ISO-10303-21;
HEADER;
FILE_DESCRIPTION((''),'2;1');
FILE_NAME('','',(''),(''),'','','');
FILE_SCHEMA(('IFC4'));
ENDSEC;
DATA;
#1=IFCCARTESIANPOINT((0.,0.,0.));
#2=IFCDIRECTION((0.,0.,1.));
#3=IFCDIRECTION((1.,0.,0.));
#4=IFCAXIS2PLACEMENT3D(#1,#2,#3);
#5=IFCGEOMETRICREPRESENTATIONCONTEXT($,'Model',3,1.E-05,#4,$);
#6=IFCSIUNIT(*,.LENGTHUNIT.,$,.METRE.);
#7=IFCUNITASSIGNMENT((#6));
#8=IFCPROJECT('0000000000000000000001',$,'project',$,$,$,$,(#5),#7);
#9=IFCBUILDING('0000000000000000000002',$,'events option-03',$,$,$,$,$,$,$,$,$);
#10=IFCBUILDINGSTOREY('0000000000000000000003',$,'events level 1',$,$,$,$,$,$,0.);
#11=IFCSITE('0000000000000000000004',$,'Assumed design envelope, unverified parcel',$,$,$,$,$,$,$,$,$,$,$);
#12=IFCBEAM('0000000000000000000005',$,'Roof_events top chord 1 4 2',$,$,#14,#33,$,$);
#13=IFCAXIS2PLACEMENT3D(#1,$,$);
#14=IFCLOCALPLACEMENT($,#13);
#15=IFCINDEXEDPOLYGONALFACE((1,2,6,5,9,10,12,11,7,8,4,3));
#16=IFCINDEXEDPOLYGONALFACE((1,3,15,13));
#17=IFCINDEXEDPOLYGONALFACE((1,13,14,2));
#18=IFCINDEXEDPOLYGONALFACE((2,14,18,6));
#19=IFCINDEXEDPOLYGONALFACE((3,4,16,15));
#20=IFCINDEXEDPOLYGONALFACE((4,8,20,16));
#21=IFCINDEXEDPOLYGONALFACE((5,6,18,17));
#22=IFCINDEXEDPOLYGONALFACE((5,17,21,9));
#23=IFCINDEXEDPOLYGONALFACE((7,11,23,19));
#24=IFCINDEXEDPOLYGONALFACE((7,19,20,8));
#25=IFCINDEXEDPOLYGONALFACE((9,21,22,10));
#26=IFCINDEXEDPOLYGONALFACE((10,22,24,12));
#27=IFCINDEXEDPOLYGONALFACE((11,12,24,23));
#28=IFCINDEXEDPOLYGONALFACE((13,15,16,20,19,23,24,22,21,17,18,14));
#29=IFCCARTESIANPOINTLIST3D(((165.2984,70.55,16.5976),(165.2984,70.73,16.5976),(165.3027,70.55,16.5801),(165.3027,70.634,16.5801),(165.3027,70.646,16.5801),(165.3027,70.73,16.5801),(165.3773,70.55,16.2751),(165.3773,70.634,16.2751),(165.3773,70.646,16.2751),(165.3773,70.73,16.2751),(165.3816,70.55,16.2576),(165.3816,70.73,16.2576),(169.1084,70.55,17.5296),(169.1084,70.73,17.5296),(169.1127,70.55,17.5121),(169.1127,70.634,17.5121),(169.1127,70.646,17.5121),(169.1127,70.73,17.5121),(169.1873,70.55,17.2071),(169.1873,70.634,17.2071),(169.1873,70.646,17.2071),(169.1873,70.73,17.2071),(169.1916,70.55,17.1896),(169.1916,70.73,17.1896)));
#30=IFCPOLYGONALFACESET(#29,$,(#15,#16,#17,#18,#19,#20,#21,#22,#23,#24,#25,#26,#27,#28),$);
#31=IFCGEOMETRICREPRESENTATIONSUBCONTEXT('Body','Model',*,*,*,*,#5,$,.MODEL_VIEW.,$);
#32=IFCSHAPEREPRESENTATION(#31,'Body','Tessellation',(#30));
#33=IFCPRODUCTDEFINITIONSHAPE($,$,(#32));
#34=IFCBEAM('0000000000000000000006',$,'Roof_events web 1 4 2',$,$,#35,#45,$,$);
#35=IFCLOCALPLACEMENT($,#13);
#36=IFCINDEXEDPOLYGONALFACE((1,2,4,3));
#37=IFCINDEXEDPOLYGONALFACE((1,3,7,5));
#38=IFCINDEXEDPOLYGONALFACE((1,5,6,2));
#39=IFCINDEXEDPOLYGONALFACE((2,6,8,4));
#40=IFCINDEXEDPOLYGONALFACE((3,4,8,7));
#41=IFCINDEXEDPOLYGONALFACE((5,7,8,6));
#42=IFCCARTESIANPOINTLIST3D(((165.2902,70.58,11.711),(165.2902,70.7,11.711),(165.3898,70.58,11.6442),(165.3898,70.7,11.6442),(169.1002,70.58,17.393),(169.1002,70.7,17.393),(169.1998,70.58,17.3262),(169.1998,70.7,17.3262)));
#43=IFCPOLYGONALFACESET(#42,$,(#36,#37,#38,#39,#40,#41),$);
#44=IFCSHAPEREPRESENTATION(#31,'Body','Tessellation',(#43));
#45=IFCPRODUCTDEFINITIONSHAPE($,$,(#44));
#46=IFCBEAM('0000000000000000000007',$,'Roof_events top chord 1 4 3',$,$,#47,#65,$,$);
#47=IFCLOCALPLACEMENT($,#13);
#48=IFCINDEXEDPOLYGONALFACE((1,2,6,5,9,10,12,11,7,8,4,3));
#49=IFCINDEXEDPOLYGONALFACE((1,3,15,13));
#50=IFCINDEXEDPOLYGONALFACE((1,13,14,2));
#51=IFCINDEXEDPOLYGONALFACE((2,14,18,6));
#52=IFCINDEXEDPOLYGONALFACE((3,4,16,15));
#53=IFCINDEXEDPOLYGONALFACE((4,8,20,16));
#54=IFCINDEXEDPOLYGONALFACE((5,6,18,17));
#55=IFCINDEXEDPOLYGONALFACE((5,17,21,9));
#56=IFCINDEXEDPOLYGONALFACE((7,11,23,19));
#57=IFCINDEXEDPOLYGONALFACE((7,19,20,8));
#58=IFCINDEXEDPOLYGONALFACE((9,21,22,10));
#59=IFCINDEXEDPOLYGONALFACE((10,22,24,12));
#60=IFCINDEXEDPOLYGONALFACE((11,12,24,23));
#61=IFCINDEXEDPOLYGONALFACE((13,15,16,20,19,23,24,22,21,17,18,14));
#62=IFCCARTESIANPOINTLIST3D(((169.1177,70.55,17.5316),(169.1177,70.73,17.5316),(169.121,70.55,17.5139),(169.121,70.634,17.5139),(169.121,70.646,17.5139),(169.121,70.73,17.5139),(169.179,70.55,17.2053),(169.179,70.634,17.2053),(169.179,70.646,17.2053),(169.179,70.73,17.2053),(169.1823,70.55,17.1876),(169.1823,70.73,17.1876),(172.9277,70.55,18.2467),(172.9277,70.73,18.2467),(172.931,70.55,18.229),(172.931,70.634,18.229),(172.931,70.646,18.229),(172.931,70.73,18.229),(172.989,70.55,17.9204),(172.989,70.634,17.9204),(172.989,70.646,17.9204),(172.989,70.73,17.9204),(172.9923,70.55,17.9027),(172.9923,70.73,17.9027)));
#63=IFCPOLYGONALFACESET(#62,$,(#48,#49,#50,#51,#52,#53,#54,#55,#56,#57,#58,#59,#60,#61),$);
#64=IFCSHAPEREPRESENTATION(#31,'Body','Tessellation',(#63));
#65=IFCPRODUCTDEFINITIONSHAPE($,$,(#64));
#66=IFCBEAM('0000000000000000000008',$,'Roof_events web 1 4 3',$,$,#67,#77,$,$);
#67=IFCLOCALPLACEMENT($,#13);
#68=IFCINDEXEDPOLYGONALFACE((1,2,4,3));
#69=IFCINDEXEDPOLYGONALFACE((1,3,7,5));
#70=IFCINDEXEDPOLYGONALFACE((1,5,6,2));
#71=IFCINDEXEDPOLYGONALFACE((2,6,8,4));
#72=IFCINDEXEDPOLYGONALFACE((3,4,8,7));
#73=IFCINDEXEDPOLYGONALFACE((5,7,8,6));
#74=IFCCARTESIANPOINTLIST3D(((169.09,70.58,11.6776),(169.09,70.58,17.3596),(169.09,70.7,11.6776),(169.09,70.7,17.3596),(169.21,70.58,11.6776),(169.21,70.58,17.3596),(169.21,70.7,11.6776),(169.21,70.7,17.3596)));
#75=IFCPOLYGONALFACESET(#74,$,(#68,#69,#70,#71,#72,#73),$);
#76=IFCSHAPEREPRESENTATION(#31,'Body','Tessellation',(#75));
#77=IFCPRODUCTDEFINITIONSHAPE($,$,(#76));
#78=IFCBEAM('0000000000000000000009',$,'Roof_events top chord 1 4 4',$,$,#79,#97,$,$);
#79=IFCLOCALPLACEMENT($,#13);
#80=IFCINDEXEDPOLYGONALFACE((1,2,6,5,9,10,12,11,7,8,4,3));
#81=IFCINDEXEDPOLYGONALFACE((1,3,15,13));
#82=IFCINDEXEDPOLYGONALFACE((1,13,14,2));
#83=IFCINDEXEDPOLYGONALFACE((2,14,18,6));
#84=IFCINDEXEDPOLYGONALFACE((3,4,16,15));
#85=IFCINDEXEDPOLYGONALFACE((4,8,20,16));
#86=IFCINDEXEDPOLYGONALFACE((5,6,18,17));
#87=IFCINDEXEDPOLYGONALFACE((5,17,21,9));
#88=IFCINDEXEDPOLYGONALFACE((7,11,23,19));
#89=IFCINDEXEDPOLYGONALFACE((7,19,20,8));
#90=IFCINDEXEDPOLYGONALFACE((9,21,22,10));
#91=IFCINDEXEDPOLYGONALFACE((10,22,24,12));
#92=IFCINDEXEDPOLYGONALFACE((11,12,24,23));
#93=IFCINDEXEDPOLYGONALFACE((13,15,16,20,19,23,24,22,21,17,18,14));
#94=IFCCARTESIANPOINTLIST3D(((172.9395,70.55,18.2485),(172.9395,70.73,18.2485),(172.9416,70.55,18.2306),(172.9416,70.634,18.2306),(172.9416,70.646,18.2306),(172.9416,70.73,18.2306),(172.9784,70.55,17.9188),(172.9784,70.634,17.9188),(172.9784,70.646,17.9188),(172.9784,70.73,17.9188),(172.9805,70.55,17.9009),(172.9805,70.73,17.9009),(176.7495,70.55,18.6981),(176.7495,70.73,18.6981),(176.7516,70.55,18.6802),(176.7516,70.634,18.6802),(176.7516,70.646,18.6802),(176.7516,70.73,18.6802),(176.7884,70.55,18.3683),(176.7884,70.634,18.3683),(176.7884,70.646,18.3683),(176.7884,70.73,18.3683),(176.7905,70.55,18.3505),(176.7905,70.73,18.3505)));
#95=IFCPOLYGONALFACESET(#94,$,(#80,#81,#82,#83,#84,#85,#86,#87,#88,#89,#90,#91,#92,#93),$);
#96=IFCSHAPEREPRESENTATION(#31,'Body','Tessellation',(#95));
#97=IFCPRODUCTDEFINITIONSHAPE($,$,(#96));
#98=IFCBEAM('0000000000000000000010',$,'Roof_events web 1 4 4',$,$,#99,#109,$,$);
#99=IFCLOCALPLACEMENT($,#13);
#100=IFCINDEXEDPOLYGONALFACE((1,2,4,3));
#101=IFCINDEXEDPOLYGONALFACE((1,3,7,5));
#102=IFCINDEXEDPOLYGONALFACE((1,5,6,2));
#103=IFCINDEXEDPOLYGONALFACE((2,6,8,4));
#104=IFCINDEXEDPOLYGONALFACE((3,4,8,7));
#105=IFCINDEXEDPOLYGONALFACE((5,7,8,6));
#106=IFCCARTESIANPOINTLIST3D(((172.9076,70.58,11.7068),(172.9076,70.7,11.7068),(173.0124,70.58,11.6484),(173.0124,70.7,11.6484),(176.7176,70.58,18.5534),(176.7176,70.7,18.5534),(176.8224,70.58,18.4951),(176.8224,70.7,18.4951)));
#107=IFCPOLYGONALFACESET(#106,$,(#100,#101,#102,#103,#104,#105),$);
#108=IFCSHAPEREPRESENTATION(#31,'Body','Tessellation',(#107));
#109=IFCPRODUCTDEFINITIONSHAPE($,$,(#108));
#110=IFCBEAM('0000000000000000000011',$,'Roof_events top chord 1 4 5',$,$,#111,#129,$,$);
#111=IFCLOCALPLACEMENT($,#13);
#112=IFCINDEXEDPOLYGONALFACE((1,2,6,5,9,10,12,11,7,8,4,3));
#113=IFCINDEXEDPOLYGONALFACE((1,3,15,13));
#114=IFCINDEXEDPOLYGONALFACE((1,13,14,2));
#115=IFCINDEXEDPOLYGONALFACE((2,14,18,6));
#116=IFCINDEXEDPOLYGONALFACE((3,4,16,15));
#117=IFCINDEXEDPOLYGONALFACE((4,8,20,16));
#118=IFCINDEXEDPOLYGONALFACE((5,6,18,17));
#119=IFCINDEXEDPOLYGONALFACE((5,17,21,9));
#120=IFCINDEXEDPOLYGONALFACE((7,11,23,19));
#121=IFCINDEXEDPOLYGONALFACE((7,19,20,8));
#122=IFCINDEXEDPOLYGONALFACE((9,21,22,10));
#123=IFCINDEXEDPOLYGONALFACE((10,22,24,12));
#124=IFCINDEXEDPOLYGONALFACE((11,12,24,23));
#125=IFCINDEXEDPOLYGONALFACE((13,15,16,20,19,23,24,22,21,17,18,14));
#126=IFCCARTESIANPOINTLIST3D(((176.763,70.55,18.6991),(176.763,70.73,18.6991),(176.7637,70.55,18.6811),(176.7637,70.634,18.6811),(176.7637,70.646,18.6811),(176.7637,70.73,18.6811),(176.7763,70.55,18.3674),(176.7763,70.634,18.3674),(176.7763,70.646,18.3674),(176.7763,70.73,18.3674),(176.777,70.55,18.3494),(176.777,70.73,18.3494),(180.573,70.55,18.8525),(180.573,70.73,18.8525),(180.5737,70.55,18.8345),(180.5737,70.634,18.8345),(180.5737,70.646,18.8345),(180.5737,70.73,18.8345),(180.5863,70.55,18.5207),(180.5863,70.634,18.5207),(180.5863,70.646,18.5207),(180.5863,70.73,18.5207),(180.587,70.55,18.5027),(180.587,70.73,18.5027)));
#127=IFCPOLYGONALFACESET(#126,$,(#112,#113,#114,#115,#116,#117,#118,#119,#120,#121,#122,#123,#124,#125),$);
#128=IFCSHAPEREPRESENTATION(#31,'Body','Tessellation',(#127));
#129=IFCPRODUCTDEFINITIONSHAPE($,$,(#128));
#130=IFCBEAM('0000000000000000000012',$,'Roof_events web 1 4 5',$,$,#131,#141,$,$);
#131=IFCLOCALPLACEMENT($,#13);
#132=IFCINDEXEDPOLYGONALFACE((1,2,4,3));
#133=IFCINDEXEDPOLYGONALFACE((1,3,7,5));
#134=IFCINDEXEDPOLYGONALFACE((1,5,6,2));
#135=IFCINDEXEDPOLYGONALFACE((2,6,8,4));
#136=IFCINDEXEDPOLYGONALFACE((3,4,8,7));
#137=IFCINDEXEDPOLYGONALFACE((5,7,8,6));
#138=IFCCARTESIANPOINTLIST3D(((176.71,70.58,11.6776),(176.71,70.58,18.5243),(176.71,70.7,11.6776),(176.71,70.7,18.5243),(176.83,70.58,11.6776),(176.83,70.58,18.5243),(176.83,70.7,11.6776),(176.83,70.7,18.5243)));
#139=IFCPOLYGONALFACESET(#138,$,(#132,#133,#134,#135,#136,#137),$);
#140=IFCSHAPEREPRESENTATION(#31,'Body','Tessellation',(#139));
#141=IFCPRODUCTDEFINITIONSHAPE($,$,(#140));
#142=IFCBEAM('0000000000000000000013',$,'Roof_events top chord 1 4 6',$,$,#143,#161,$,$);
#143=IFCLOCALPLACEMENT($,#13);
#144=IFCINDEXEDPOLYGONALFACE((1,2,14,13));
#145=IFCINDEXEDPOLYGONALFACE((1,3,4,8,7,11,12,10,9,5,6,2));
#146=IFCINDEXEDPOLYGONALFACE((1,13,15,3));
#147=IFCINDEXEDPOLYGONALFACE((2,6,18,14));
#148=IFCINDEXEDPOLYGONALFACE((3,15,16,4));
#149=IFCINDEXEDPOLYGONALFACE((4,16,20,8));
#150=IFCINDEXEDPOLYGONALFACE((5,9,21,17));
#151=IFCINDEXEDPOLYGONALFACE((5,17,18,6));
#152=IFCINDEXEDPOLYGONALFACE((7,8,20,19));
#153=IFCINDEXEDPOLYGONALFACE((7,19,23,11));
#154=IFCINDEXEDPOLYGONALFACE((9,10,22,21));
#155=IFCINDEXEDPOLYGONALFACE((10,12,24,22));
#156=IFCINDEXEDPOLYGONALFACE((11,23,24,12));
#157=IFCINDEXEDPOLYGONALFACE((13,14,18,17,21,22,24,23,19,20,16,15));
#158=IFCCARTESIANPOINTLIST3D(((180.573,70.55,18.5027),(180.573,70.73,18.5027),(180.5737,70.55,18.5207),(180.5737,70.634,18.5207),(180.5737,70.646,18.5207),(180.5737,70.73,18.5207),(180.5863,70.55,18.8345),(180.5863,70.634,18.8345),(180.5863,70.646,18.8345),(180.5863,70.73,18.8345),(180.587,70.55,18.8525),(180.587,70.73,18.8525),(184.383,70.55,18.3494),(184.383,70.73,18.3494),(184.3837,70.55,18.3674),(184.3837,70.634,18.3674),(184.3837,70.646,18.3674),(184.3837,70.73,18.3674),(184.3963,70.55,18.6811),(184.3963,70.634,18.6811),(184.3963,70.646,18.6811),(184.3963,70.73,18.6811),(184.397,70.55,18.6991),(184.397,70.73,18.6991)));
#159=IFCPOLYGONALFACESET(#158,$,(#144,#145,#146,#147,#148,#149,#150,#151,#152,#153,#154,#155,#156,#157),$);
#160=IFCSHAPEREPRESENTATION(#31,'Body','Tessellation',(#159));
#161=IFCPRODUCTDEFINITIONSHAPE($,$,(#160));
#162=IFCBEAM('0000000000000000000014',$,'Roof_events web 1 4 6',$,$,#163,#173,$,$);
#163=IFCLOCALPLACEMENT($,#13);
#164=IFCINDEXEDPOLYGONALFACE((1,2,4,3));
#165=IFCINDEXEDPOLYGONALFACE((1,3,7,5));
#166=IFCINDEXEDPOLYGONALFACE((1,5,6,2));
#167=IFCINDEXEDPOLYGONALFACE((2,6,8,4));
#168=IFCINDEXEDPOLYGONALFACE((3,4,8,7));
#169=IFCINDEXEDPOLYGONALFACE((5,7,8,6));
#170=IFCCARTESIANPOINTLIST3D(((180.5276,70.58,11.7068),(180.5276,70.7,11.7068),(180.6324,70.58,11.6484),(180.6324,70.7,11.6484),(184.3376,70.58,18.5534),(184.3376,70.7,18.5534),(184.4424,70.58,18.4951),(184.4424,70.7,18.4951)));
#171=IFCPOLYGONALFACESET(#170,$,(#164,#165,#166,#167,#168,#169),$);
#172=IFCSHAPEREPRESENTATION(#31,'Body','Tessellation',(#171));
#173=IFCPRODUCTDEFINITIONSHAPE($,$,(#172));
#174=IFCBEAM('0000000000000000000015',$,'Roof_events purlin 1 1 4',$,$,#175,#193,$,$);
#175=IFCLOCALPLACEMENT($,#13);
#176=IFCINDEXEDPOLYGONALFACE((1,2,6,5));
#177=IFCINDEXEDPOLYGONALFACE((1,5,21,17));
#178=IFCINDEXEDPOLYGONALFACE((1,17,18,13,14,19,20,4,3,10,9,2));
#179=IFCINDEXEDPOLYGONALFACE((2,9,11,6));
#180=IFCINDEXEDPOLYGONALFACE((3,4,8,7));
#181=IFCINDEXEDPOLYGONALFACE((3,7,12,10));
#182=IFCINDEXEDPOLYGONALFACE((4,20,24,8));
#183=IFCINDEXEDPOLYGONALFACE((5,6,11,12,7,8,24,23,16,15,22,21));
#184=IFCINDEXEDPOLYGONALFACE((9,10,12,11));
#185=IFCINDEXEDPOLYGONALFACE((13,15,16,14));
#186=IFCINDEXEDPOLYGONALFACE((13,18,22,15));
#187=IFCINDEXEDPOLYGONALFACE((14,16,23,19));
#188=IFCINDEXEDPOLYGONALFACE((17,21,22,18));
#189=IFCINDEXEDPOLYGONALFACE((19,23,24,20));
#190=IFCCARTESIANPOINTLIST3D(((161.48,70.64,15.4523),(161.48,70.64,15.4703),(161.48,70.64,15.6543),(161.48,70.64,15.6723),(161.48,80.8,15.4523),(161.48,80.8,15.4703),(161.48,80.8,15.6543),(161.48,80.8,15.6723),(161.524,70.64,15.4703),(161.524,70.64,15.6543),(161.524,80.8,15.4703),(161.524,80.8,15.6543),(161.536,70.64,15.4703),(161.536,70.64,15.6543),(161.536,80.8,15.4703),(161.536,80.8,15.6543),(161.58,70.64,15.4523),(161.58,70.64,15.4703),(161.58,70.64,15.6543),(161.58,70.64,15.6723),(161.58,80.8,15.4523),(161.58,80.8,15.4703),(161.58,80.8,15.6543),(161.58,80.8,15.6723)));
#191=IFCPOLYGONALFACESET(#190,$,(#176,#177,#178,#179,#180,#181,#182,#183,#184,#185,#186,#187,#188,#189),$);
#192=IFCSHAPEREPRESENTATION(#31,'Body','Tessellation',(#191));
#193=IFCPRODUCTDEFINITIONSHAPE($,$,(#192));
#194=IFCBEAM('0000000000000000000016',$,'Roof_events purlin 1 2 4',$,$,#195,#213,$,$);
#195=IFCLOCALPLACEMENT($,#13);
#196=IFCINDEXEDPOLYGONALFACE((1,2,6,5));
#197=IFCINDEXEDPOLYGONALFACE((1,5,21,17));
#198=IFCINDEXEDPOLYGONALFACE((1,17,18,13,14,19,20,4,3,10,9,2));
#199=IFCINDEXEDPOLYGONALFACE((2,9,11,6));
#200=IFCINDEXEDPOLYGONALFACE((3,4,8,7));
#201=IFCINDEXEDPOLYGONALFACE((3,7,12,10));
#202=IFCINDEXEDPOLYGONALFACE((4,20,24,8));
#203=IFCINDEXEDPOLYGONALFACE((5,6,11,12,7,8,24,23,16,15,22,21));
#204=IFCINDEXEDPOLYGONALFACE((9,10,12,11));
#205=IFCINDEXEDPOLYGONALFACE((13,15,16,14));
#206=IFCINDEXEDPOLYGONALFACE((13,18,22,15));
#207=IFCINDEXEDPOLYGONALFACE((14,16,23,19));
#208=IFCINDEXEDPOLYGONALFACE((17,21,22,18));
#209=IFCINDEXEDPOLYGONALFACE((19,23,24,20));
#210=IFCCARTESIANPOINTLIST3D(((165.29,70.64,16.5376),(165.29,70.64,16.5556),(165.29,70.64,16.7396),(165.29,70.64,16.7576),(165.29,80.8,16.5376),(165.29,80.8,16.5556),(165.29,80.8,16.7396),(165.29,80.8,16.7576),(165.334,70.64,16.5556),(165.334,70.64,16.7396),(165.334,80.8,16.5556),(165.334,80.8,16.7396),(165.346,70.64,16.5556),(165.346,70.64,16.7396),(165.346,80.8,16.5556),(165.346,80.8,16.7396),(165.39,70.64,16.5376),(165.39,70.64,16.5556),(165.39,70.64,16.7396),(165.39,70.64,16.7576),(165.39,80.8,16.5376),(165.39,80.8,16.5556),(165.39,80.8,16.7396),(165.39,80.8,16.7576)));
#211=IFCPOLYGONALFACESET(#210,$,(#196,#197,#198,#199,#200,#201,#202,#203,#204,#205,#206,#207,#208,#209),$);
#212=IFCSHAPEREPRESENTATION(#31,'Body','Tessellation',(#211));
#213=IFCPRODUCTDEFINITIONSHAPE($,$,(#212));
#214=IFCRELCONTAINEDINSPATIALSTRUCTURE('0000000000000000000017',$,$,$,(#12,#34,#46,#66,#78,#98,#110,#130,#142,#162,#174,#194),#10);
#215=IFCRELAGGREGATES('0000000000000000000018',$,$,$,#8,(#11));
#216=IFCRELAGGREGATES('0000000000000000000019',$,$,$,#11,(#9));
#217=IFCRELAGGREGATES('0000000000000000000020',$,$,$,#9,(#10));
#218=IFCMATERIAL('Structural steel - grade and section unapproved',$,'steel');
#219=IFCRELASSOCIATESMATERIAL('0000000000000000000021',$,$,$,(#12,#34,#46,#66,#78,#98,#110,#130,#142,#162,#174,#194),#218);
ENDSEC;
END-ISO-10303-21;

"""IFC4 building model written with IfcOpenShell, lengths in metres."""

from ifc_helpers import new_model, si_unit, frame, origin_with_axes, place, context, subcontext, project, spatial, rectangle, i_section, extrude, material, element, save


model = new_model("IFC4")

# Units and contexts
model_context = context("Model", 3, precision=1e-05, world=origin_with_axes())
body_context = subcontext(model_context, "Body", "Model", "MODEL_VIEW")
ifc_project = project(units=[si_unit("LENGTHUNIT", "METRE")], contexts=[model_context])

# Site, building, storey
site = spatial("IfcSite", under=ifc_project, Name="Assumed design envelope, unverified parcel")
building = spatial("IfcBuilding", under=site, Name="events option-03")
storey = spatial("IfcBuildingStorey", under=building, Name="events level 1", Elevation=0.0)

# Shared definitions
ifc_material_1 = material(Name="Structural steel - grade and section unapproved", Category="steel")

# Beams
beam_1_placement = place(None, frame((165.34, 70.64, 16.4276), z_axis=(0.971361, 0.0, 0.237609), x_axis=(0.0, 1.0, 0.0)))
element("IfcBeam", 1, at=beam_1_placement, inside=storey, material=ifc_material_1, Name="Roof_events top chord 1 4 2", context=body_context, shape_type="SweptSolid", body=[
    extrude(i_section(OverallWidth=0.18, OverallDepth=0.35, WebThickness=0.012, FlangeThickness=0.018, FilletRadius=0.0), origin_with_axes(), (0.0, 0.0, 1.0), 3.9223),
])
beam_2_placement = place(None, frame((165.34, 70.64, 11.6776), z_axis=(0.556926, 0.0, 0.830562), x_axis=(0.0, 1.0, 0.0)))
element("IfcBeam", 2, at=beam_2_placement, inside=storey, material=ifc_material_1, Name="Roof_events web 1 4 2", context=body_context, shape_type="SweptSolid", body=[
    extrude(rectangle(XDim=0.12, YDim=0.12), origin_with_axes(), (0.0, 0.0, 1.0), 6.8411),
])
beam_3_placement = place(None, frame((169.15, 70.64, 17.3596), z_axis=(0.982837, 0.0, 0.184477), x_axis=(0.0, 1.0, 0.0)))
element("IfcBeam", 3, at=beam_3_placement, inside=storey, material=ifc_material_1, Name="Roof_events top chord 1 4 3", context=body_context, shape_type="SweptSolid", body=[
    extrude(i_section(OverallWidth=0.18, OverallDepth=0.35, WebThickness=0.012, FlangeThickness=0.018, FilletRadius=0.0), origin_with_axes(), (0.0, 0.0, 1.0), 3.8765),
])
beam_4_placement = place(None, frame((169.15, 70.64, 11.6776), z_axis=(0.0, 0.0, 1.0), x_axis=(-1.0, 0.0, 0.0)))
element("IfcBeam", 4, at=beam_4_placement, inside=storey, material=ifc_material_1, Name="Roof_events web 1 4 3", context=body_context, shape_type="SweptSolid", body=[
    extrude(rectangle(XDim=0.12, YDim=0.12), origin_with_axes(), (0.0, 0.0, 1.0), 5.682),
])
beam_5_placement = place(None, frame((172.96, 70.64, 18.0747), z_axis=(0.993111, 0.0, 0.117179), x_axis=(0.0, 1.0, 0.0)))
element("IfcBeam", 5, at=beam_5_placement, inside=storey, material=ifc_material_1, Name="Roof_events top chord 1 4 4", context=body_context, shape_type="SweptSolid", body=[
    extrude(i_section(OverallWidth=0.18, OverallDepth=0.35, WebThickness=0.012, FlangeThickness=0.018, FilletRadius=0.0), origin_with_axes(), (0.0, 0.0, 1.0), 3.8364),
])
beam_6_placement = place(None, frame((172.96, 70.64, 11.6776), z_axis=(0.486257, 0.0, 0.873816), x_axis=(0.0, 1.0, 0.0)))
element("IfcBeam", 6, at=beam_6_placement, inside=storey, material=ifc_material_1, Name="Roof_events web 1 4 4", context=body_context, shape_type="SweptSolid", body=[
    extrude(rectangle(XDim=0.12, YDim=0.12), origin_with_axes(), (0.0, 0.0, 1.0), 7.8354),
])
beam_7_placement = place(None, frame((176.77, 70.64, 18.5243), z_axis=(0.999191, 0.0, 0.040213), x_axis=(0.0, 1.0, 0.0)))
element("IfcBeam", 7, at=beam_7_placement, inside=storey, material=ifc_material_1, Name="Roof_events top chord 1 4 5", context=body_context, shape_type="SweptSolid", body=[
    extrude(i_section(OverallWidth=0.18, OverallDepth=0.35, WebThickness=0.012, FlangeThickness=0.018, FilletRadius=0.0), origin_with_axes(), (0.0, 0.0, 1.0), 3.8131),
])
beam_8_placement = place(None, frame((176.77, 70.64, 11.6776), z_axis=(0.0, 0.0, 1.0), x_axis=(-1.0, 0.0, 0.0)))
element("IfcBeam", 8, at=beam_8_placement, inside=storey, material=ifc_material_1, Name="Roof_events web 1 4 5", context=body_context, shape_type="SweptSolid", body=[
    extrude(rectangle(XDim=0.12, YDim=0.12), origin_with_axes(), (0.0, 0.0, 1.0), 6.8467),
])
beam_9_placement = place(None, frame((180.58, 70.64, 18.6776), z_axis=(0.999191, 0.0, -0.040212), x_axis=(0.0, 1.0, 0.0)))
element("IfcBeam", 9, at=beam_9_placement, inside=storey, material=ifc_material_1, Name="Roof_events top chord 1 4 6", context=body_context, shape_type="SweptSolid", body=[
    extrude(i_section(OverallWidth=0.18, OverallDepth=0.35, WebThickness=0.012, FlangeThickness=0.018, FilletRadius=0.0), origin_with_axes(), (0.0, 0.0, 1.0), 3.8131),
])
beam_10_placement = place(None, frame((180.58, 70.64, 11.6776), z_axis=(0.486257, 0.0, 0.873816), x_axis=(0.0, 1.0, 0.0)))
element("IfcBeam", 10, at=beam_10_placement, inside=storey, material=ifc_material_1, Name="Roof_events web 1 4 6", context=body_context, shape_type="SweptSolid", body=[
    extrude(rectangle(XDim=0.12, YDim=0.12), origin_with_axes(), (0.0, 0.0, 1.0), 7.8354),
])
for number, where, z_axis, x_axis, name in (
    (11, (161.53, 70.64, 15.5623), (0.0, 1.0, 0.0), (-1.0, 0.0, 0.0), "Roof_events purlin 1 1 4"),
    (12, (165.34, 70.64, 16.6476), (0.0, 1.0, 0.0), (-1.0, 0.0, 0.0), "Roof_events purlin 1 2 4"),
):
    element("IfcBeam", number, at=place(None, frame(where, z_axis=z_axis, x_axis=x_axis)), inside=storey, material=ifc_material_1, Name=name, context=body_context, shape_type="SweptSolid", body=[
        extrude(i_section(OverallWidth=0.1, OverallDepth=0.22, WebThickness=0.012, FlangeThickness=0.018, FilletRadius=0.0), origin_with_axes(), (0.0, 0.0, 1.0), 10.16),
    ])

save(model, "model.ifc")
